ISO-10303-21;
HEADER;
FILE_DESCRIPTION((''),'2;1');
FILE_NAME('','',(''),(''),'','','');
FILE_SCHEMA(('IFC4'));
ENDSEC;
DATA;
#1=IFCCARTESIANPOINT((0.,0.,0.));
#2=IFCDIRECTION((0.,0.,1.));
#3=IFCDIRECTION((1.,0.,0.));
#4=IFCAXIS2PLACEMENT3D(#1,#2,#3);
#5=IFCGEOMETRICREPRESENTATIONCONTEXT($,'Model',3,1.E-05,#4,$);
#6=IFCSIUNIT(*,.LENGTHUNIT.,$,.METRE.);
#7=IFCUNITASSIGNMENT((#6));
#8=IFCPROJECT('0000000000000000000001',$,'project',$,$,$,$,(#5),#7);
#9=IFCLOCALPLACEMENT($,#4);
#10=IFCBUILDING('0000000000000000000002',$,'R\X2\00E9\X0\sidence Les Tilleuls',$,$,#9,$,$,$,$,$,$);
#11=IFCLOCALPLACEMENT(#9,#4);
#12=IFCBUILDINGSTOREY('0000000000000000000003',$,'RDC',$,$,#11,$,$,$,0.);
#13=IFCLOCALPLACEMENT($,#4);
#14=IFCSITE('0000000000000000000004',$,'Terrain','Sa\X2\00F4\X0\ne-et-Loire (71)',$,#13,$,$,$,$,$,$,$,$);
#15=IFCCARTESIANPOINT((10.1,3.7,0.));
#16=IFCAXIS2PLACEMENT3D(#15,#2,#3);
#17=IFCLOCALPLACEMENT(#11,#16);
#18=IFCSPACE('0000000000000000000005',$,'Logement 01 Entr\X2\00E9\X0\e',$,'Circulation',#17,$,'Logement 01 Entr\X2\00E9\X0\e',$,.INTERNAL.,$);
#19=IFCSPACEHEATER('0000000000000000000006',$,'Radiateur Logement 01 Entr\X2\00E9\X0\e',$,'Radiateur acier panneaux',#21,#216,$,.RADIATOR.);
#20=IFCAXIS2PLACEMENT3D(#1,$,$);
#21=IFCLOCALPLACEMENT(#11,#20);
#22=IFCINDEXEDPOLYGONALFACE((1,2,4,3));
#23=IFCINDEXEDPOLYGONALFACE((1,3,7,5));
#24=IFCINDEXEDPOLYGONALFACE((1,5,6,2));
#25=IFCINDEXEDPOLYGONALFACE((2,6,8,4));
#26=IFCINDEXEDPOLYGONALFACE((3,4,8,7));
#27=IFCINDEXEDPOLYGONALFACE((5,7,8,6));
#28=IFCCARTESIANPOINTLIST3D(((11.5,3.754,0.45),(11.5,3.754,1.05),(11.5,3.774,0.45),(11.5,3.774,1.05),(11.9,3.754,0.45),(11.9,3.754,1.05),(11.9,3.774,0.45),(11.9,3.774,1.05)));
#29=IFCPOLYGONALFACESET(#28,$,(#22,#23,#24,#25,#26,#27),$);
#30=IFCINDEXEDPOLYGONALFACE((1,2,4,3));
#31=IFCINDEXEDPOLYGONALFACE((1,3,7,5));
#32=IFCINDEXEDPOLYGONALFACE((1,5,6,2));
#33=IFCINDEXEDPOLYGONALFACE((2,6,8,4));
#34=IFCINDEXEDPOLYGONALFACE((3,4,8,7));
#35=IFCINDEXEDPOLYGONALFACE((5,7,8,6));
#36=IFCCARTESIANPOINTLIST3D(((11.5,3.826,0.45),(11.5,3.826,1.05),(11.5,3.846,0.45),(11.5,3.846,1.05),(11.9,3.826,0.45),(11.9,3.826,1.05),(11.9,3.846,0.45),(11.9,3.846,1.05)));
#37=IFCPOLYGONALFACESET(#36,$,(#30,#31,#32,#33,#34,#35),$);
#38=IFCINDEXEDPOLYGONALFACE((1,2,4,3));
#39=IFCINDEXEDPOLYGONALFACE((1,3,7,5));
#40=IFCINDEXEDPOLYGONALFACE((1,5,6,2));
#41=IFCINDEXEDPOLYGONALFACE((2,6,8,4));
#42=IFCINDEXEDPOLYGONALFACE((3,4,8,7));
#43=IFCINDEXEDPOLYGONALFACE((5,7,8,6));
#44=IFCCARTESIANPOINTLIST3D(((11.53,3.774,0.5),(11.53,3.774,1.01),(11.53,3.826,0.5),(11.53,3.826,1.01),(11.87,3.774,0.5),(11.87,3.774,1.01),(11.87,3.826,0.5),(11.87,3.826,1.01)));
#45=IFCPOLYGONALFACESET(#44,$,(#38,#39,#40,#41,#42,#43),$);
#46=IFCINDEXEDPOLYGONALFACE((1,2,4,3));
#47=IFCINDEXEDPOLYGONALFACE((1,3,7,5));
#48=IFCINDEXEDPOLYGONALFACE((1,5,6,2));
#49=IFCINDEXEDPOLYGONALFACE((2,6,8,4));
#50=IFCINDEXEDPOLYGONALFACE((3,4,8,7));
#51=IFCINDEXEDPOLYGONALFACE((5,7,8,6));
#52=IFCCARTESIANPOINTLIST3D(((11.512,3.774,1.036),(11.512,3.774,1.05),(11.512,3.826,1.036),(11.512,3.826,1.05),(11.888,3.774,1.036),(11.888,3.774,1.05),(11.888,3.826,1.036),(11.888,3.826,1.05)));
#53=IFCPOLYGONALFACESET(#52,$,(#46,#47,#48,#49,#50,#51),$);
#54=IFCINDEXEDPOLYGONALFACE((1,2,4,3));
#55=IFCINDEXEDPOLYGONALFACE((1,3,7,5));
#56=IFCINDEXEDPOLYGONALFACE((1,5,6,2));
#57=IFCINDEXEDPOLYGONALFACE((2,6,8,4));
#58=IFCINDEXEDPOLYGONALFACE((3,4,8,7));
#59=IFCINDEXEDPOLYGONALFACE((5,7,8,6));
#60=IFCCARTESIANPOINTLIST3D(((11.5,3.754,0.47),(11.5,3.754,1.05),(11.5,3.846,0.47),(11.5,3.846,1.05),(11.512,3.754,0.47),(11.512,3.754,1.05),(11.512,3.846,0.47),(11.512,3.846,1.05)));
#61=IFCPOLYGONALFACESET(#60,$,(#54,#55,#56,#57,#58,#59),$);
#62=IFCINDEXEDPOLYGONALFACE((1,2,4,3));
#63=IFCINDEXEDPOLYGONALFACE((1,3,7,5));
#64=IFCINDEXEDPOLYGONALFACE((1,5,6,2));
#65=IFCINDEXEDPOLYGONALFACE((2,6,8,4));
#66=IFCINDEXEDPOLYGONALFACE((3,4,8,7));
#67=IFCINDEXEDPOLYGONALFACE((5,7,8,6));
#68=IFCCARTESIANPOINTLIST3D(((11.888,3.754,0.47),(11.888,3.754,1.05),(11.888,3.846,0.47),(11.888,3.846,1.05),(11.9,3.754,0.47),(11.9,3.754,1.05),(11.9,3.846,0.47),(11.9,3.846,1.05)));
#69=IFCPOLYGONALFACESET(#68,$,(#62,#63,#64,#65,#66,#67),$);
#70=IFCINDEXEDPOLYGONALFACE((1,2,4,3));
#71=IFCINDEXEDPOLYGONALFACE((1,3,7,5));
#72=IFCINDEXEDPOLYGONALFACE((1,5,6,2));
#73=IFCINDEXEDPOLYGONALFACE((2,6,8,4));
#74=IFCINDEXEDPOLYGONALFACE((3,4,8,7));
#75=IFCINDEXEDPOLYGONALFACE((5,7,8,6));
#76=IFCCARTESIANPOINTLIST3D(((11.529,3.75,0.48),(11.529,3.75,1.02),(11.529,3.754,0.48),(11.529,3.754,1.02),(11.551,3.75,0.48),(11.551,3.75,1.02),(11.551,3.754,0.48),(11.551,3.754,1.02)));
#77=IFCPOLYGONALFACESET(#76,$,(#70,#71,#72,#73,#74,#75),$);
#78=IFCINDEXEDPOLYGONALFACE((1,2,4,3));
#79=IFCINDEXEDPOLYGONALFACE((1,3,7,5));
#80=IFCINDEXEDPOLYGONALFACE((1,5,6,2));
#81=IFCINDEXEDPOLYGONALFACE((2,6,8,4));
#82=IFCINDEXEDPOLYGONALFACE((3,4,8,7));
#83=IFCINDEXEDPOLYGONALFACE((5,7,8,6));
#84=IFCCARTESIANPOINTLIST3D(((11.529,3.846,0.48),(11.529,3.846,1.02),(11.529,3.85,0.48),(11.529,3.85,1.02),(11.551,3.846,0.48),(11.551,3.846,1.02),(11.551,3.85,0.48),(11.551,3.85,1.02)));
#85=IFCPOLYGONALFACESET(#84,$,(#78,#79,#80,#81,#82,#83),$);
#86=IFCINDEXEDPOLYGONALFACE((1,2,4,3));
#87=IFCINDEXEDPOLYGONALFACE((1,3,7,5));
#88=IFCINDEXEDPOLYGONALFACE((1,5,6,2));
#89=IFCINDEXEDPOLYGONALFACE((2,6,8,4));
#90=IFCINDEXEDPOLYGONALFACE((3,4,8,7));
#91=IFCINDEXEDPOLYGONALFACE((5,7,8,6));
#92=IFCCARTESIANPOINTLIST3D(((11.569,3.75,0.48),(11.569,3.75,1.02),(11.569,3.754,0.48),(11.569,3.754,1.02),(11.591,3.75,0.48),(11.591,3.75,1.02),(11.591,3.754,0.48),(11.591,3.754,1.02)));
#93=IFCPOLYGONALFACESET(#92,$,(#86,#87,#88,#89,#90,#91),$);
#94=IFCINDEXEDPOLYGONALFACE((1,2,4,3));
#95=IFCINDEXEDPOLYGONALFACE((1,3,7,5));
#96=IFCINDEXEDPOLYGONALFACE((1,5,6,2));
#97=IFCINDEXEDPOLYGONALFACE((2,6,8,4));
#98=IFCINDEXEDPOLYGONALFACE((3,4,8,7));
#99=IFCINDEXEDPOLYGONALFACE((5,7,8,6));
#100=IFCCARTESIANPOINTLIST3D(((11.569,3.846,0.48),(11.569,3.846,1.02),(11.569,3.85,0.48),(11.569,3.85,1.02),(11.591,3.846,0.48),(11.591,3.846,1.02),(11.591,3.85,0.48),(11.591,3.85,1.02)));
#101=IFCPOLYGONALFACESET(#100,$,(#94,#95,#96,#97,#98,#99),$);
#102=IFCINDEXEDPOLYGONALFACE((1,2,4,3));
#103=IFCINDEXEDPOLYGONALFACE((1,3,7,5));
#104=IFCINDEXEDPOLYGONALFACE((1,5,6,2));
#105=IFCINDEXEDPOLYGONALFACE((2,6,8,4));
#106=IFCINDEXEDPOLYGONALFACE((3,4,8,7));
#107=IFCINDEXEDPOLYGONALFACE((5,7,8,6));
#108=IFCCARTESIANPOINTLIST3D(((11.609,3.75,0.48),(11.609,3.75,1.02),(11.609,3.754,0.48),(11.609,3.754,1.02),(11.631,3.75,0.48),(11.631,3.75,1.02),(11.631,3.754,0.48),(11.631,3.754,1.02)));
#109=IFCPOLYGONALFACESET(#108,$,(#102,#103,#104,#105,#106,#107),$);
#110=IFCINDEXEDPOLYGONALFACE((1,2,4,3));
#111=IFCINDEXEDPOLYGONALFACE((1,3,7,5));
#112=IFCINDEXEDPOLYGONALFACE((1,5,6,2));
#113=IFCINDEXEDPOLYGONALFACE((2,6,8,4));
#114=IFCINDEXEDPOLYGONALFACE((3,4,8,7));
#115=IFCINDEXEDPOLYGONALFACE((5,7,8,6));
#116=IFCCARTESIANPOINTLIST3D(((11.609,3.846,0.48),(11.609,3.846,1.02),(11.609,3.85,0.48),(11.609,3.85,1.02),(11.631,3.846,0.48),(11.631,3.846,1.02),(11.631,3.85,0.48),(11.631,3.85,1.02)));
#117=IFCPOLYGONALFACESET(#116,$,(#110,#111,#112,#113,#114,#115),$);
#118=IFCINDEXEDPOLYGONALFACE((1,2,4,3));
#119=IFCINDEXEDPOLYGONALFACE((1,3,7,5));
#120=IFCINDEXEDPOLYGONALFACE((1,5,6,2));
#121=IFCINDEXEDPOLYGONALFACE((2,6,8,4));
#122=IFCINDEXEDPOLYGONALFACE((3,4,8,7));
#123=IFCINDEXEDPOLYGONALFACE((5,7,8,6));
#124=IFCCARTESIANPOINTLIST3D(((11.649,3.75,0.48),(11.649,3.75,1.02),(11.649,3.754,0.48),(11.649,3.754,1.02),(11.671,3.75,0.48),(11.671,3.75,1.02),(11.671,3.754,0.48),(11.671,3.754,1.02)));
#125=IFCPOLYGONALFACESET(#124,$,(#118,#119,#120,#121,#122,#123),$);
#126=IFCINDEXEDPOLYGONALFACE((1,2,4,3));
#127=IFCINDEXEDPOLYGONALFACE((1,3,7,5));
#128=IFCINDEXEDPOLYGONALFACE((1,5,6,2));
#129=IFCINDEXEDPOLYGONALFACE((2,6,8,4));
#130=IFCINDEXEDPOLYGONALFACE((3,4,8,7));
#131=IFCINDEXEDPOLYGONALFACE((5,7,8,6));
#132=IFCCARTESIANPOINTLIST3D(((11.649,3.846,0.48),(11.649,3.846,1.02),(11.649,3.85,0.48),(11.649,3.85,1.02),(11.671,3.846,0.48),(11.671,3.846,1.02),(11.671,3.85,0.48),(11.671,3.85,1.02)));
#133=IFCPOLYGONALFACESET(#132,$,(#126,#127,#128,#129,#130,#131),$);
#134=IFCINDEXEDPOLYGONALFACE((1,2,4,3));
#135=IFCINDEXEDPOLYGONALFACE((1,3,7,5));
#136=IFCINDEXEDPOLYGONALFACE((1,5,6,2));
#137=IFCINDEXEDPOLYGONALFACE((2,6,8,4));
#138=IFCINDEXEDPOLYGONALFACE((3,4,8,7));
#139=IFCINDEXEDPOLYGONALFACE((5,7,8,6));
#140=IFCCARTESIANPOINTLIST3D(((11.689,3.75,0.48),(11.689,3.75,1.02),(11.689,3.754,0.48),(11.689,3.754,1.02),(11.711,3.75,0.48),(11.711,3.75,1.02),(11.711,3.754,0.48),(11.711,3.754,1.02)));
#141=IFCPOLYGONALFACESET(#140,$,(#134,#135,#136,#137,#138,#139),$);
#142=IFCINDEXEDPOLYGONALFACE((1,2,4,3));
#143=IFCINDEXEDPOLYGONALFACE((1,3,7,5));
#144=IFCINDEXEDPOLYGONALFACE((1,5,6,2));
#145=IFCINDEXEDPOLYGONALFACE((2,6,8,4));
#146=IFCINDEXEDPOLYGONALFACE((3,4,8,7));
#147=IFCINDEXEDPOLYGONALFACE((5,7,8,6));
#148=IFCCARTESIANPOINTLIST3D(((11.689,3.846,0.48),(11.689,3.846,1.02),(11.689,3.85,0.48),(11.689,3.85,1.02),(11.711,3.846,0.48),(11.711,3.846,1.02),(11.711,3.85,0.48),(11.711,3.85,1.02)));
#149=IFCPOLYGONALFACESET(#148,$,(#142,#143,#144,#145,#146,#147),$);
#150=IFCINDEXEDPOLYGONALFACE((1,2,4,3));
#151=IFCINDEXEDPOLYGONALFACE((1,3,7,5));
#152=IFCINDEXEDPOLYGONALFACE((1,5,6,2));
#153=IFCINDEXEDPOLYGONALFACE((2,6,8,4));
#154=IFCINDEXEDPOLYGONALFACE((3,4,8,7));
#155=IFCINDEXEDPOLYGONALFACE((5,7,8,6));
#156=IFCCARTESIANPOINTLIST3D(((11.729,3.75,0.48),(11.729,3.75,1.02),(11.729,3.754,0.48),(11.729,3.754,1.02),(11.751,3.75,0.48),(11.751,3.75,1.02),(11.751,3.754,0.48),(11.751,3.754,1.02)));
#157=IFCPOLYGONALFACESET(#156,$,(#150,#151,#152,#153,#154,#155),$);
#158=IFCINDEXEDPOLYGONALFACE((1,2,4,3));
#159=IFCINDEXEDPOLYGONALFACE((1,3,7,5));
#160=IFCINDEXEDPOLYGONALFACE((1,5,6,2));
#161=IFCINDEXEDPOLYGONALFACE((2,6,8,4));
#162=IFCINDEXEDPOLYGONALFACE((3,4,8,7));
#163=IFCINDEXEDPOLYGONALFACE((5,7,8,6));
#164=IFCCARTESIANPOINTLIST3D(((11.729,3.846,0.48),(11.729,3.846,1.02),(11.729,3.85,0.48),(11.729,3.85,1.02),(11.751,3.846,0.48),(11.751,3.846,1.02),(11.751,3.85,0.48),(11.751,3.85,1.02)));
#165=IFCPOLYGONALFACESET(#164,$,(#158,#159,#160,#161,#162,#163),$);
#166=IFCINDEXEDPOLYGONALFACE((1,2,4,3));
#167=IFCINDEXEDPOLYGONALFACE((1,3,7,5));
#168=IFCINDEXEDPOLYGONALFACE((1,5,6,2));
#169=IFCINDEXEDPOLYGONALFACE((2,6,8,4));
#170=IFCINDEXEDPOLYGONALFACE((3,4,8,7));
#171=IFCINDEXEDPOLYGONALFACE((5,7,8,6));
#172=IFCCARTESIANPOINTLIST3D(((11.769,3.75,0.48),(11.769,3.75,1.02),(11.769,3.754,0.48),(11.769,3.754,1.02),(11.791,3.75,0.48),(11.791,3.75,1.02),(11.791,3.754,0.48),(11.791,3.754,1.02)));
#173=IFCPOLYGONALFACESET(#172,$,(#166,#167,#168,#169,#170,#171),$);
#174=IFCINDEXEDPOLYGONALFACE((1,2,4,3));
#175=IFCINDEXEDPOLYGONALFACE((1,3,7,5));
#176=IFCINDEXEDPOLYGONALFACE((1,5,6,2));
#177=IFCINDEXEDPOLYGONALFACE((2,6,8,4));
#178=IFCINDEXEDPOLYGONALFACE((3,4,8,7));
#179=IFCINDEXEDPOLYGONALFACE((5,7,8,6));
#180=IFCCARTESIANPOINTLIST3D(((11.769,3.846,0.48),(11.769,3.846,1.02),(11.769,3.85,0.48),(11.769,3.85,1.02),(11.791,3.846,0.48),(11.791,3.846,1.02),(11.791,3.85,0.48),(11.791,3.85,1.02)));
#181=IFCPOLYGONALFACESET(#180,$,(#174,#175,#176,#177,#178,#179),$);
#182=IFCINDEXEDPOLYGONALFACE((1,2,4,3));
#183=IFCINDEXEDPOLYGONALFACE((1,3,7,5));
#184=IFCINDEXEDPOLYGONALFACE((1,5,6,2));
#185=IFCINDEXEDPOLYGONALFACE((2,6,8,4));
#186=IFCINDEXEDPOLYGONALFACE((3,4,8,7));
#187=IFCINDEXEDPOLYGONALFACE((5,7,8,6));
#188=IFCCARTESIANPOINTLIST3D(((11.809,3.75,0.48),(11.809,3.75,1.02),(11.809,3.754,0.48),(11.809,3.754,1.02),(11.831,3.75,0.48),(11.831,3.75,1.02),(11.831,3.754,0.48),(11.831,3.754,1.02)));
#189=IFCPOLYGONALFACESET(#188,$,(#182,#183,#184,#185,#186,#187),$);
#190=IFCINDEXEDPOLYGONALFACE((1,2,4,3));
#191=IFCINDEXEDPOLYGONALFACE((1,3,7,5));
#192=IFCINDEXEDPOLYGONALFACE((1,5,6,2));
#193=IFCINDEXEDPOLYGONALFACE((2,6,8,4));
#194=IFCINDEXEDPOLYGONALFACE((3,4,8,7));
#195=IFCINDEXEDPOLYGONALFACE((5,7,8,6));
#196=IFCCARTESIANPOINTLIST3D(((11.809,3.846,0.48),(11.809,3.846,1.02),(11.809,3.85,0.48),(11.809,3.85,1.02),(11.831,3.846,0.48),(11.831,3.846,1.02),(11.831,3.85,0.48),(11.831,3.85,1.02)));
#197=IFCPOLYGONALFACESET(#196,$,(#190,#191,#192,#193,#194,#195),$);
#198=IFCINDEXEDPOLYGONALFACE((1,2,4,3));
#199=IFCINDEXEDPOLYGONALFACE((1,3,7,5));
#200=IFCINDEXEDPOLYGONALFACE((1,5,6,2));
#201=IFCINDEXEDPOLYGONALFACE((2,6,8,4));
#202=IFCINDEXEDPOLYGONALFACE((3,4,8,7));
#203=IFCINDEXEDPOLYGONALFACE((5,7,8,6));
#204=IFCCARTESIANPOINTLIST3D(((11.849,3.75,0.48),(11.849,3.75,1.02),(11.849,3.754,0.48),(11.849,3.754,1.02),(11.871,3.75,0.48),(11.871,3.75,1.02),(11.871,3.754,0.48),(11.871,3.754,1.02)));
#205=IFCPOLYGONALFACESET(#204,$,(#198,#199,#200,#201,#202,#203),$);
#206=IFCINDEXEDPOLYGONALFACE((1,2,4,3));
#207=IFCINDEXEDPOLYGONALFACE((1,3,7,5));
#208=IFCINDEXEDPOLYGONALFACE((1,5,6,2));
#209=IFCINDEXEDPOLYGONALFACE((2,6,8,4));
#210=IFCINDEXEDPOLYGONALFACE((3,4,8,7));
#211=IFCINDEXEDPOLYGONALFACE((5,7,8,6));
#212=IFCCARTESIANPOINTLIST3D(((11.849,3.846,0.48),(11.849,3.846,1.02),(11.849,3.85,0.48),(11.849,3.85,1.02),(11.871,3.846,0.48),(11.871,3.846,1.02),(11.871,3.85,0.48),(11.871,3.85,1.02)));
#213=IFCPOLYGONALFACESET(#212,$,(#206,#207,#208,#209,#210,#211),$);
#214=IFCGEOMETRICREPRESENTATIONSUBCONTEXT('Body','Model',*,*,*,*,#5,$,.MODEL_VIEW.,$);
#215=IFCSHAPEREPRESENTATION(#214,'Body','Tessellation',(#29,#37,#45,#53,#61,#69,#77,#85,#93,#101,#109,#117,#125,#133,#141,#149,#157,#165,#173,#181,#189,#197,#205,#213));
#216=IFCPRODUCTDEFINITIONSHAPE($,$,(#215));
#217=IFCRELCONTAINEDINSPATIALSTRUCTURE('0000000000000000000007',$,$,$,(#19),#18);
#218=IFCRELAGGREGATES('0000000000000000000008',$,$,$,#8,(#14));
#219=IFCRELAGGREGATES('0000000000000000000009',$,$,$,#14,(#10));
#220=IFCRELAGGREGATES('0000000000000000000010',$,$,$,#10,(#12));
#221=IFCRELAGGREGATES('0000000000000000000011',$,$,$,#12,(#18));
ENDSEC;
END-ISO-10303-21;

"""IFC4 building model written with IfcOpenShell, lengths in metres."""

from ifc_helpers import new_model, si_unit, frame, frame_2d, origin_with_axes, place, context, subcontext, project, spatial, rectangle, extrude, element, save


model = new_model("IFC4")

# Units and contexts
model_context = context("Model", 3, precision=1e-05, world=origin_with_axes())
body_context = subcontext(model_context, "Body", "Model", "MODEL_VIEW")
ifc_project = project(units=[si_unit("LENGTHUNIT", "METRE")], contexts=[model_context])

# Site, building, storey
site_placement = place(None, origin_with_axes())
site = spatial("IfcSite", under=ifc_project, at=site_placement, Name="Terrain", Description="Saône-et-Loire (71)")
building_placement = place(None, origin_with_axes())
building = spatial("IfcBuilding", under=site, at=building_placement, Name="Résidence Les Tilleuls")
storey_placement = place(building_placement, origin_with_axes())
storey = spatial("IfcBuildingStorey", under=building, at=storey_placement, Name="RDC", Elevation=0.0)

# Shared definitions
space_1_placement = place(storey_placement, frame((10.1, 3.7, 0.0), z_axis=(0.0, 0.0, 1.0), x_axis=(1.0, 0.0, 0.0)))
space_1 = spatial("IfcSpace", under=storey, at=space_1_placement, Name="Logement 01 Entrée", ObjectType="Circulation", LongName="Logement 01 Entrée", PredefinedType="INTERNAL")

# Space heater
space_heater_placement = place(space_1_placement, frame((1.4, 0.05, 0.45), z_axis=(0.0, 0.0, 1.0), x_axis=(1.0, 0.0, 0.0)))
element("IfcSpaceHeater", 1, at=space_heater_placement, inside=space_1, Name="Radiateur Logement 01 Entrée", ObjectType="Radiateur acier panneaux", PredefinedType="RADIATOR", context=body_context, shape_type="SweptSolid", body=[
    extrude(rectangle(XDim=0.4, YDim=0.02, at=frame_2d((0.2, 0.01))), frame((0.0, 0.004, 0.0), z_axis=(0.0, 0.0, 1.0), x_axis=(1.0, 0.0, 0.0)), (0.0, 0.0, 1.0), 0.6),
    extrude(rectangle(XDim=0.4, YDim=0.02, at=frame_2d((0.2, 0.01))), frame((0.0, 0.076, 0.0), z_axis=(0.0, 0.0, 1.0), x_axis=(1.0, 0.0, 0.0)), (0.0, 0.0, 1.0), 0.6),
    extrude(rectangle(XDim=0.34, YDim=0.052, at=frame_2d((0.17, 0.026))), frame((0.03, 0.024, 0.05), z_axis=(0.0, 0.0, 1.0), x_axis=(1.0, 0.0, 0.0)), (0.0, 0.0, 1.0), 0.51),
    extrude(rectangle(XDim=0.376, YDim=0.052, at=frame_2d((0.188, 0.026))), frame((0.012, 0.024, 0.586), z_axis=(0.0, 0.0, 1.0), x_axis=(1.0, 0.0, 0.0)), (0.0, 0.0, 1.0), 0.014),
    extrude(rectangle(XDim=0.012, YDim=0.092, at=frame_2d((0.006, 0.046))), frame((0.0, 0.004, 0.02), z_axis=(0.0, 0.0, 1.0), x_axis=(1.0, 0.0, 0.0)), (0.0, 0.0, 1.0), 0.58),
    extrude(rectangle(XDim=0.012, YDim=0.092, at=frame_2d((0.006, 0.046))), frame((0.388, 0.004, 0.02), z_axis=(0.0, 0.0, 1.0), x_axis=(1.0, 0.0, 0.0)), (0.0, 0.0, 1.0), 0.58),
    extrude(rectangle(XDim=0.022, YDim=0.004, at=frame_2d((0.011, 0.002))), frame((0.029, 0.0, 0.03), z_axis=(0.0, 0.0, 1.0), x_axis=(1.0, 0.0, 0.0)), (0.0, 0.0, 1.0), 0.54),
    extrude(rectangle(XDim=0.022, YDim=0.004, at=frame_2d((0.011, 0.002))), frame((0.029, 0.096, 0.03), z_axis=(0.0, 0.0, 1.0), x_axis=(1.0, 0.0, 0.0)), (0.0, 0.0, 1.0), 0.54),
    extrude(rectangle(XDim=0.022, YDim=0.004, at=frame_2d((0.011, 0.002))), frame((0.069, 0.0, 0.03), z_axis=(0.0, 0.0, 1.0), x_axis=(1.0, 0.0, 0.0)), (0.0, 0.0, 1.0), 0.54),
    extrude(rectangle(XDim=0.022, YDim=0.004, at=frame_2d((0.011, 0.002))), frame((0.069, 0.096, 0.03), z_axis=(0.0, 0.0, 1.0), x_axis=(1.0, 0.0, 0.0)), (0.0, 0.0, 1.0), 0.54),
    extrude(rectangle(XDim=0.022, YDim=0.004, at=frame_2d((0.011, 0.002))), frame((0.109, 0.0, 0.03), z_axis=(0.0, 0.0, 1.0), x_axis=(1.0, 0.0, 0.0)), (0.0, 0.0, 1.0), 0.54),
    extrude(rectangle(XDim=0.022, YDim=0.004, at=frame_2d((0.011, 0.002))), frame((0.109, 0.096, 0.03), z_axis=(0.0, 0.0, 1.0), x_axis=(1.0, 0.0, 0.0)), (0.0, 0.0, 1.0), 0.54),
    extrude(rectangle(XDim=0.022, YDim=0.004, at=frame_2d((0.011, 0.002))), frame((0.149, 0.0, 0.03), z_axis=(0.0, 0.0, 1.0), x_axis=(1.0, 0.0, 0.0)), (0.0, 0.0, 1.0), 0.54),
    extrude(rectangle(XDim=0.022, YDim=0.004, at=frame_2d((0.011, 0.002))), frame((0.149, 0.096, 0.03), z_axis=(0.0, 0.0, 1.0), x_axis=(1.0, 0.0, 0.0)), (0.0, 0.0, 1.0), 0.54),
    extrude(rectangle(XDim=0.022, YDim=0.004, at=frame_2d((0.011, 0.002))), frame((0.189, 0.0, 0.03), z_axis=(0.0, 0.0, 1.0), x_axis=(1.0, 0.0, 0.0)), (0.0, 0.0, 1.0), 0.54),
    extrude(rectangle(XDim=0.022, YDim=0.004, at=frame_2d((0.011, 0.002))), frame((0.189, 0.096, 0.03), z_axis=(0.0, 0.0, 1.0), x_axis=(1.0, 0.0, 0.0)), (0.0, 0.0, 1.0), 0.54),
    extrude(rectangle(XDim=0.022, YDim=0.004, at=frame_2d((0.011, 0.002))), frame((0.229, 0.0, 0.03), z_axis=(0.0, 0.0, 1.0), x_axis=(1.0, 0.0, 0.0)), (0.0, 0.0, 1.0), 0.54),
    extrude(rectangle(XDim=0.022, YDim=0.004, at=frame_2d((0.011, 0.002))), frame((0.229, 0.096, 0.03), z_axis=(0.0, 0.0, 1.0), x_axis=(1.0, 0.0, 0.0)), (0.0, 0.0, 1.0), 0.54),
    extrude(rectangle(XDim=0.022, YDim=0.004, at=frame_2d((0.011, 0.002))), frame((0.269, 0.0, 0.03), z_axis=(0.0, 0.0, 1.0), x_axis=(1.0, 0.0, 0.0)), (0.0, 0.0, 1.0), 0.54),
    extrude(rectangle(XDim=0.022, YDim=0.004, at=frame_2d((0.011, 0.002))), frame((0.269, 0.096, 0.03), z_axis=(0.0, 0.0, 1.0), x_axis=(1.0, 0.0, 0.0)), (0.0, 0.0, 1.0), 0.54),
    extrude(rectangle(XDim=0.022, YDim=0.004, at=frame_2d((0.011, 0.002))), frame((0.309, 0.0, 0.03), z_axis=(0.0, 0.0, 1.0), x_axis=(1.0, 0.0, 0.0)), (0.0, 0.0, 1.0), 0.54),
    extrude(rectangle(XDim=0.022, YDim=0.004, at=frame_2d((0.011, 0.002))), frame((0.309, 0.096, 0.03), z_axis=(0.0, 0.0, 1.0), x_axis=(1.0, 0.0, 0.0)), (0.0, 0.0, 1.0), 0.54),
    extrude(rectangle(XDim=0.022, YDim=0.004, at=frame_2d((0.011, 0.002))), frame((0.349, 0.0, 0.03), z_axis=(0.0, 0.0, 1.0), x_axis=(1.0, 0.0, 0.0)), (0.0, 0.0, 1.0), 0.54),
    extrude(rectangle(XDim=0.022, YDim=0.004, at=frame_2d((0.011, 0.002))), frame((0.349, 0.096, 0.03), z_axis=(0.0, 0.0, 1.0), x_axis=(1.0, 0.0, 0.0)), (0.0, 0.0, 1.0), 0.54),
])

save(model, "model.ifc")
